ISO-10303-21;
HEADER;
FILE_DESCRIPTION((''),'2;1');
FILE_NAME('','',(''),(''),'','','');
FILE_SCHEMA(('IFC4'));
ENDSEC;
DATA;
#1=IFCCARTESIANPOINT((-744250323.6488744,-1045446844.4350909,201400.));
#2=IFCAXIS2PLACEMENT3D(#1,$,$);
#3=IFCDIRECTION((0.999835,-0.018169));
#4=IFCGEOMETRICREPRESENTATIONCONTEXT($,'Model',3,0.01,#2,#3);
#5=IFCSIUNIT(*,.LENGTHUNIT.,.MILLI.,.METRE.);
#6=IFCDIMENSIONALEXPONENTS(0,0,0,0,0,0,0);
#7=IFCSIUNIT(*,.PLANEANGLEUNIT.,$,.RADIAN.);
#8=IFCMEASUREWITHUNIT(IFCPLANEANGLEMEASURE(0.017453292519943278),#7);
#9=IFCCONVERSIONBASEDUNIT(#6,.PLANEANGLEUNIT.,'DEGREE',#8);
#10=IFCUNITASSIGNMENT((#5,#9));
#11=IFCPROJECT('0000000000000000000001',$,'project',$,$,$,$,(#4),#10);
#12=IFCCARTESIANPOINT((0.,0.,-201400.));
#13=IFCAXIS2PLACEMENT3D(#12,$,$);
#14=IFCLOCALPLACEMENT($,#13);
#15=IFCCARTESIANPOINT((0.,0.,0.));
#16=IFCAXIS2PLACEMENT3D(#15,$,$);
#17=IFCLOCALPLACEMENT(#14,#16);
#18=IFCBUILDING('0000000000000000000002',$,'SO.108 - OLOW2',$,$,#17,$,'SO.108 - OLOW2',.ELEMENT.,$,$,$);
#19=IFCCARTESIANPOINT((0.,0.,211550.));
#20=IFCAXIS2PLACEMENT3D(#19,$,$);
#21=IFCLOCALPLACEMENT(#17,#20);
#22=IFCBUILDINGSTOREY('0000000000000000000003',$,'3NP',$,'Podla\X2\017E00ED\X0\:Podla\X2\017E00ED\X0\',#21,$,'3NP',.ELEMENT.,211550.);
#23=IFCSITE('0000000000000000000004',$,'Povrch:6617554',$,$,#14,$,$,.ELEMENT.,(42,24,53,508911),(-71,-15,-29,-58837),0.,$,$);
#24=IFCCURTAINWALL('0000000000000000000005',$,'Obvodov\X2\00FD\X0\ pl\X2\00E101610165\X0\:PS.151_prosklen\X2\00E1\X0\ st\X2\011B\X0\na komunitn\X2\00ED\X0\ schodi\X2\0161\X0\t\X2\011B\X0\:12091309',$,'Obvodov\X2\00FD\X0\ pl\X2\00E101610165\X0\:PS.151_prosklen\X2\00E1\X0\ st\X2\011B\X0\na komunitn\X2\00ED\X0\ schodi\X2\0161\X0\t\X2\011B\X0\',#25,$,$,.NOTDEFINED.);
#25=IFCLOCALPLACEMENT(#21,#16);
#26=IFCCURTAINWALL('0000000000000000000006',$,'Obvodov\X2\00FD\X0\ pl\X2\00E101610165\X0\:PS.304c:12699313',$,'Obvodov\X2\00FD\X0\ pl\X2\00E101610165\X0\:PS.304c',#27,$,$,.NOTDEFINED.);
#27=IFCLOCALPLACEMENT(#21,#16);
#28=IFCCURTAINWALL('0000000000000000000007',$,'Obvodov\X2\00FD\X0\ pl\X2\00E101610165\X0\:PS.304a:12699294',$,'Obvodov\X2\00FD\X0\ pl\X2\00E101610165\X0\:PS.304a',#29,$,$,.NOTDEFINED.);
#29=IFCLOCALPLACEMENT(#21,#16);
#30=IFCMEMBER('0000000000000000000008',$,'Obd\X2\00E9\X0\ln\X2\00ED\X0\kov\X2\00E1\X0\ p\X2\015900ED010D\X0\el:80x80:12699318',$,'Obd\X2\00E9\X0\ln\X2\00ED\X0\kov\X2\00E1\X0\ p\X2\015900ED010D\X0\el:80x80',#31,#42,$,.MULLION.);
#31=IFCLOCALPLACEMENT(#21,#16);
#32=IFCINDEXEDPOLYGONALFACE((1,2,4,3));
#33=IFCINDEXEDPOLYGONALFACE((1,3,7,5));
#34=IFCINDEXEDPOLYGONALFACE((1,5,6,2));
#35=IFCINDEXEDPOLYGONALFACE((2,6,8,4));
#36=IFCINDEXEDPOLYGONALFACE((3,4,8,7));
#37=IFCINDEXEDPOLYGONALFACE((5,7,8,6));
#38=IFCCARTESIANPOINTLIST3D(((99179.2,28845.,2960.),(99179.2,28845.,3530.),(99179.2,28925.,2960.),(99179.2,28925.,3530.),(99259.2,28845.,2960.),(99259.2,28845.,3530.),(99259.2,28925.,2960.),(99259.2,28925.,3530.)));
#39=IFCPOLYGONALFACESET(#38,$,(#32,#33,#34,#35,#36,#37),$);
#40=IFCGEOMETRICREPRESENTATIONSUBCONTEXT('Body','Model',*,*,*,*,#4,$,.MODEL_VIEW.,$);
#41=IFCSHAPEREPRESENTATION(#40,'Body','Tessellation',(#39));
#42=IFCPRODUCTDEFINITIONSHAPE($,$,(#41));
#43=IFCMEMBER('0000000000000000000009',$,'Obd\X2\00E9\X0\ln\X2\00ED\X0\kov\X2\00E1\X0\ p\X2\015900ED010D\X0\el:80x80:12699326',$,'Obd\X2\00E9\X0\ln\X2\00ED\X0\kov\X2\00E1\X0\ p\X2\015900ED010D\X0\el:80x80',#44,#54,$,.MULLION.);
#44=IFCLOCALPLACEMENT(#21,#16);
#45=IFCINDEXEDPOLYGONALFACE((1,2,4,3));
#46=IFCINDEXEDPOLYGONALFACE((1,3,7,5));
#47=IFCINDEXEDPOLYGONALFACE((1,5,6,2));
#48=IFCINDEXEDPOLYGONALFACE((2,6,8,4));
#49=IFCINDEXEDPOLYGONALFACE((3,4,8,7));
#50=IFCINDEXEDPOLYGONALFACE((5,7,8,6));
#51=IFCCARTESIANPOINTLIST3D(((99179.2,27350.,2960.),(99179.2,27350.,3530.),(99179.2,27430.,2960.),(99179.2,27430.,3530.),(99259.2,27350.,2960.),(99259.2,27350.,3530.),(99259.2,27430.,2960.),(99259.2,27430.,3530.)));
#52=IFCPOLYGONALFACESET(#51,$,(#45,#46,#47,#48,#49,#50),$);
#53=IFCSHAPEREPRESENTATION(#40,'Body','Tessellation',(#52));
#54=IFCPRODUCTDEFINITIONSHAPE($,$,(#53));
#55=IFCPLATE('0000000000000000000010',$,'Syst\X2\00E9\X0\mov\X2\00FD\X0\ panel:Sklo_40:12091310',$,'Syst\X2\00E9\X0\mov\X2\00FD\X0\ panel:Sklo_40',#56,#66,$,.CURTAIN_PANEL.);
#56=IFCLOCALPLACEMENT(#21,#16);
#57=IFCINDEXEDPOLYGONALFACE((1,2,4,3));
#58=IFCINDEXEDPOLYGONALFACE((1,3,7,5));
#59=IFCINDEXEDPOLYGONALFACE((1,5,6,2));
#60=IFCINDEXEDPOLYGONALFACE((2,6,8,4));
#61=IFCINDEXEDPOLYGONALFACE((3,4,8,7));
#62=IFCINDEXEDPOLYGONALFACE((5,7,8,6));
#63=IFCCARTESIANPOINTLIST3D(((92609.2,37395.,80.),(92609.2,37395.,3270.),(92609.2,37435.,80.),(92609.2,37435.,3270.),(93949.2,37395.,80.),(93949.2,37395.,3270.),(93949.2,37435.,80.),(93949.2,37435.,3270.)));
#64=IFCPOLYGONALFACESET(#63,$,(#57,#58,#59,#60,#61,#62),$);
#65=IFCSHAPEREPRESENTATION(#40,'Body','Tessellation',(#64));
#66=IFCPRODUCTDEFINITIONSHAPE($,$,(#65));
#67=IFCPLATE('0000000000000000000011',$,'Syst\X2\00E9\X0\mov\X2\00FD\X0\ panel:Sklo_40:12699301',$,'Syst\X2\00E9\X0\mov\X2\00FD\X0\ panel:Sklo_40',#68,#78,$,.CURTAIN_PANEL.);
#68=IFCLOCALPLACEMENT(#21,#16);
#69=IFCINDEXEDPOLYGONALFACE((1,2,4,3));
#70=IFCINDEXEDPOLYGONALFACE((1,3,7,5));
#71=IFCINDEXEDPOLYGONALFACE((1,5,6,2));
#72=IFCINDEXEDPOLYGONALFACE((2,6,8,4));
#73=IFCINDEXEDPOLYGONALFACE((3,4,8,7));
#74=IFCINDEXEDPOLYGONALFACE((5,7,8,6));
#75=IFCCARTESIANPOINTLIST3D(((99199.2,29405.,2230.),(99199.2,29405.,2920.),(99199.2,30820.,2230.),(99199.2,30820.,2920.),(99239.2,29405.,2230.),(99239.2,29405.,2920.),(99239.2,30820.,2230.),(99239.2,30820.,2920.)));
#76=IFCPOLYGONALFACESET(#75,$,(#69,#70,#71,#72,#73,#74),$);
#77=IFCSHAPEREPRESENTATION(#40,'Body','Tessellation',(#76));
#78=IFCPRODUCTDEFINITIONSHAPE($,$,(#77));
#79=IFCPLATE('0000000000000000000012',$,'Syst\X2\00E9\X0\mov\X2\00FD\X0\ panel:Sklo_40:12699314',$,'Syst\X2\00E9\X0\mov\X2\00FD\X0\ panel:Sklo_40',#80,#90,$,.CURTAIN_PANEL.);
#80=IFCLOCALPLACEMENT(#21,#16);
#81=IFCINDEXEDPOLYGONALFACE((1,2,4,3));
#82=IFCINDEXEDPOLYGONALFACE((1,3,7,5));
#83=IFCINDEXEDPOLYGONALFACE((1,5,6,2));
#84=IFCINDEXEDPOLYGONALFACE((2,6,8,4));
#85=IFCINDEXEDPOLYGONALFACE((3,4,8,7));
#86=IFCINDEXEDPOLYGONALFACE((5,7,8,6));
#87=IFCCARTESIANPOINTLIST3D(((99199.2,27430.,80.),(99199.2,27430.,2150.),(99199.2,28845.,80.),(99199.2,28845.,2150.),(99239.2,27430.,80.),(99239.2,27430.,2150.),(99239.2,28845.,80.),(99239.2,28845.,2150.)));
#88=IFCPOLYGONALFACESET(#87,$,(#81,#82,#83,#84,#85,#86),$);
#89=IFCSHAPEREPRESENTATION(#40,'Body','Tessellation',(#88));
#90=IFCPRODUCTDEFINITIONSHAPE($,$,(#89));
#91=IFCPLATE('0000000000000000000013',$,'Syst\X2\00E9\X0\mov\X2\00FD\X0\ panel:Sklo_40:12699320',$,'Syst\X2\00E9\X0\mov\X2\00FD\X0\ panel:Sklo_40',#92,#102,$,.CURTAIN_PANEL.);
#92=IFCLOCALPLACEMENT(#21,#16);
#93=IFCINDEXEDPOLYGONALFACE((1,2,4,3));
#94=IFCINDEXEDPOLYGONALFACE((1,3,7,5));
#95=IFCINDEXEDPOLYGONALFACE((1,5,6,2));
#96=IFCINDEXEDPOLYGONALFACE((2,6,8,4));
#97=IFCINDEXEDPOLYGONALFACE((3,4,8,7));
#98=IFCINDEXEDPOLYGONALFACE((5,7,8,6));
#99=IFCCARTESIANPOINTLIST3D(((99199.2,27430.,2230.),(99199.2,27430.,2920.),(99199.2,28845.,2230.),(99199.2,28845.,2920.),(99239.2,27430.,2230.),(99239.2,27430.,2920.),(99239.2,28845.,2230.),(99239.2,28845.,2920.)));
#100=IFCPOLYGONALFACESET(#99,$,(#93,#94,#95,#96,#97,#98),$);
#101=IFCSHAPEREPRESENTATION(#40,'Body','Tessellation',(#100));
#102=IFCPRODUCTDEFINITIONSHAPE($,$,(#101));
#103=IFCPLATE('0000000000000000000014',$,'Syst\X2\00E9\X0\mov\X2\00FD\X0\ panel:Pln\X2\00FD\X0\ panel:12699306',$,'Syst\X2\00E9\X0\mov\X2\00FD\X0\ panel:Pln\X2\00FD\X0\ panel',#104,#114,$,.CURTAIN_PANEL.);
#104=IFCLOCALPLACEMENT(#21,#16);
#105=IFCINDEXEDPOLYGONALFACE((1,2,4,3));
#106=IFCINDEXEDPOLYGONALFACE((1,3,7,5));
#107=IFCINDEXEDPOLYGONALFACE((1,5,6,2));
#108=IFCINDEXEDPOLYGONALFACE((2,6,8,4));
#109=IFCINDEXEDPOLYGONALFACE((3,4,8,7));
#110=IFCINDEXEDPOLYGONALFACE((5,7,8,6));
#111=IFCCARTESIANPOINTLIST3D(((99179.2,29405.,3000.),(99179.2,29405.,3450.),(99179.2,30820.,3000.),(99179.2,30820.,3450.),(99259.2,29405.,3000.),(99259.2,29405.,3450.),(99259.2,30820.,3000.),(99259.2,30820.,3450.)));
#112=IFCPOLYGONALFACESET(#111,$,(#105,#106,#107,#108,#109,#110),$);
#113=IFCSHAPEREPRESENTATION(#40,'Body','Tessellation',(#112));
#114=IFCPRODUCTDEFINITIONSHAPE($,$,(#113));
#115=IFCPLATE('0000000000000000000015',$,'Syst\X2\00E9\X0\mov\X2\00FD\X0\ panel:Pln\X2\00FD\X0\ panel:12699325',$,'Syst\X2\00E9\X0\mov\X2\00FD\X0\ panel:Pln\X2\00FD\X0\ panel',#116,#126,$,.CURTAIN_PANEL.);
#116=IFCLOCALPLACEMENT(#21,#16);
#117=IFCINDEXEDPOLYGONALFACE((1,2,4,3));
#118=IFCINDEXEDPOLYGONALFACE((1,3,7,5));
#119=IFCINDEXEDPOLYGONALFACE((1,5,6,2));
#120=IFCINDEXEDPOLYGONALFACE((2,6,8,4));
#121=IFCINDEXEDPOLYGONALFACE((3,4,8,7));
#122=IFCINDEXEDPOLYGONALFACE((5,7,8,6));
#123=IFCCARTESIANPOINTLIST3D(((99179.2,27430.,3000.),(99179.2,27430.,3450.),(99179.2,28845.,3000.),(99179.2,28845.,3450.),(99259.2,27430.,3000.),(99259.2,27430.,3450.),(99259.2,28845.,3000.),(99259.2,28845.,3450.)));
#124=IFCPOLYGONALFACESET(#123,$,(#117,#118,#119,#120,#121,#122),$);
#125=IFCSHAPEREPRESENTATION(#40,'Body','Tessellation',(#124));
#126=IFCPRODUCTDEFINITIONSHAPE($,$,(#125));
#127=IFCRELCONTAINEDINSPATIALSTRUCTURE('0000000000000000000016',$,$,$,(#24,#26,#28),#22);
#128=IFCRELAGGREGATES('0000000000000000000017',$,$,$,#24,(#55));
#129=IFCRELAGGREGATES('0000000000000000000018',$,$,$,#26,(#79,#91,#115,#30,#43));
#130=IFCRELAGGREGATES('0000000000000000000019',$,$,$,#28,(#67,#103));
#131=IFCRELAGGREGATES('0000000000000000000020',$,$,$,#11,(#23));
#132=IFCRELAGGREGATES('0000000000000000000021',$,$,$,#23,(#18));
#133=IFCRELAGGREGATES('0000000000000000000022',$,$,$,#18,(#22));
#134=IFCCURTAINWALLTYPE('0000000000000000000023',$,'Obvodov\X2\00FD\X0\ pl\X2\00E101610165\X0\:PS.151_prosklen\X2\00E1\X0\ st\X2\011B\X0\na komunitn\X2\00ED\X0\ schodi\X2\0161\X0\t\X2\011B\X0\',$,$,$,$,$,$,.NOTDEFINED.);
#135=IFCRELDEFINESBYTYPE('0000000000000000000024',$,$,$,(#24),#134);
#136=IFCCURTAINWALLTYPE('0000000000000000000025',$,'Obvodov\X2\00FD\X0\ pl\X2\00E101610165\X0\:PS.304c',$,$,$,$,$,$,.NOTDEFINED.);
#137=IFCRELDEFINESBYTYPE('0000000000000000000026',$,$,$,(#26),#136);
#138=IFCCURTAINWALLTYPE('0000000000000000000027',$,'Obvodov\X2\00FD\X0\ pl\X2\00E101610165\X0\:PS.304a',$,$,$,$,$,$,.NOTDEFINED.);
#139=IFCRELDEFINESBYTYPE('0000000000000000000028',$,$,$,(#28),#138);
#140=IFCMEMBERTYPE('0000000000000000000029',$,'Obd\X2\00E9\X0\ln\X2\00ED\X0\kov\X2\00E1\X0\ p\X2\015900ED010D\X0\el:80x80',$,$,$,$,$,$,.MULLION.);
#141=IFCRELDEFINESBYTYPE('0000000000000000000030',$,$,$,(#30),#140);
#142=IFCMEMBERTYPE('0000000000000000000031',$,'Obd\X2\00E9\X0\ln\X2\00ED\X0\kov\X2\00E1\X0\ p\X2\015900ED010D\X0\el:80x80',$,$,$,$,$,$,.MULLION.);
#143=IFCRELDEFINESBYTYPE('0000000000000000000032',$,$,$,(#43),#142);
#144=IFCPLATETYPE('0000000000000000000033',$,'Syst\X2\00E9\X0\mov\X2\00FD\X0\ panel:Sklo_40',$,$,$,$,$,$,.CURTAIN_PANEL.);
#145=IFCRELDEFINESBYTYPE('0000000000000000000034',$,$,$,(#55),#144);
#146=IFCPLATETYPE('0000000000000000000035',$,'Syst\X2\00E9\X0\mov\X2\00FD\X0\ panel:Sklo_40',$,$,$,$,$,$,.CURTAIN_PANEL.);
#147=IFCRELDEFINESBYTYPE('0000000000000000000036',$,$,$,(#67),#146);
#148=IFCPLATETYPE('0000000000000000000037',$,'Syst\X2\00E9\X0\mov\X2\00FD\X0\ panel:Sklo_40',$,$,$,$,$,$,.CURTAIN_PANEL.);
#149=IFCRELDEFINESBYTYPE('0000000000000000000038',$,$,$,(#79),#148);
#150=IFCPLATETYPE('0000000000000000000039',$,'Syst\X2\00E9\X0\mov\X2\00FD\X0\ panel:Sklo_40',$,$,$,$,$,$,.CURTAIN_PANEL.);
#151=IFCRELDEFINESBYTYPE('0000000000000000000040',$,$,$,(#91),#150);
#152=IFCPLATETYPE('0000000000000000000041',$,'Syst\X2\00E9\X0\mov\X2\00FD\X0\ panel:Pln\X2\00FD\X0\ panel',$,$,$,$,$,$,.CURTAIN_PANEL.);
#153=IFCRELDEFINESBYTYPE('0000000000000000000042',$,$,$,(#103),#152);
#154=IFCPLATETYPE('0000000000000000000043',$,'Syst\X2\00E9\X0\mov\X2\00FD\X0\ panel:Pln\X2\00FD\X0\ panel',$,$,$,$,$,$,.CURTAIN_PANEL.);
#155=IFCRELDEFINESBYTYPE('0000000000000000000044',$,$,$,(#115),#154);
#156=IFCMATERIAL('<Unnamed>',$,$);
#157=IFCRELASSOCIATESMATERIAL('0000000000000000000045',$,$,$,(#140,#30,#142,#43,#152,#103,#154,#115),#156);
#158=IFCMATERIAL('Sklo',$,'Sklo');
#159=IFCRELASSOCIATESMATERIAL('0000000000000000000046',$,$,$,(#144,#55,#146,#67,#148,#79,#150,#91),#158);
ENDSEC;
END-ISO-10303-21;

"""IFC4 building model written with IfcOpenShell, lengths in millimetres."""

from ifc_helpers import new_model, entity, si_unit, converted_unit, direction, frame, origin, place, context, subcontext, project, spatial, indexed_curve, outline, extrude, source, transform, mapped, material, type_object, type_shapes, element, aggregate, save


model = new_model("IFC4")

# Units and contexts
model_context = context("Model", 3, precision=0.01, world=frame((-744250323.6488744, -1045446844.4350909, 201400.0)), true_north=direction((0.999835, -0.018169)))
body_context = subcontext(model_context, "Body", "Model", "MODEL_VIEW")
ifc_project = project(units=[si_unit("LENGTHUNIT", "METRE", prefix="MILLI"), converted_unit("PLANEANGLEUNIT", "DEGREE", entity("IfcPlaneAngleMeasure", 0.017453292519943278), si_unit("PLANEANGLEUNIT", "RADIAN"), dimensions=[0, 0, 0, 0, 0, 0, 0])], contexts=[model_context])

# Site, building, storey
site_placement = place(None, frame((0.0, 0.0, -201400.0)))
site = spatial("IfcSite", under=ifc_project, at=site_placement, Name="Povrch:6617554", CompositionType="ELEMENT", RefLatitude=(42, 24, 53, 508911), RefLongitude=(-71, -15, -29, -58837), RefElevation=0.0)
building_placement = place(site_placement, origin())
building = spatial("IfcBuilding", under=site, at=building_placement, Name="SO.108 - OLOW2", LongName="SO.108 - OLOW2", CompositionType="ELEMENT")
storey_placement = place(building_placement, frame((0.0, 0.0, 211550.0)))
storey = spatial("IfcBuildingStorey", under=building, at=storey_placement, Name="3NP", ObjectType="Podlaží:Podlaží", LongName="3NP", CompositionType="ELEMENT", Elevation=211550.0)

# Curtain walls
curtain_wall_type_1 = type_object("IfcCurtainWallType", Name="Obvodový plášť:PS.151_prosklená stěna komunitní schodiště", PredefinedType="NOTDEFINED")
curtain_wall_1_placement = place(storey_placement, frame((0.0, 0.0, -211550.0)))
curtain_wall_1 = element("IfcCurtainWall", 1, at=curtain_wall_1_placement, inside=storey, type_object=curtain_wall_type_1, Name="Obvodový plášť:PS.151_prosklená stěna komunitní schodiště:12091309", ObjectType="Obvodový plášť:PS.151_prosklená stěna komunitní schodiště", PredefinedType="NOTDEFINED")
ifc_material_1 = material(Name="<Unnamed>")
curtain_wall_type_2 = type_object("IfcCurtainWallType", Name="Obvodový plášť:PS.304c", PredefinedType="NOTDEFINED")
curtain_wall_2_placement = place(storey_placement, frame((0.0, 0.0, -211550.0)))
curtain_wall_2 = element("IfcCurtainWall", 2, at=curtain_wall_2_placement, inside=storey, type_object=curtain_wall_type_2, Name="Obvodový plášť:PS.304c:12699313", ObjectType="Obvodový plášť:PS.304c", PredefinedType="NOTDEFINED")
curtain_wall_type_3 = type_object("IfcCurtainWallType", Name="Obvodový plášť:PS.304a", PredefinedType="NOTDEFINED")
curtain_wall_3_placement = place(storey_placement, frame((0.0, 0.0, -211550.0)))
curtain_wall_3 = element("IfcCurtainWall", 3, at=curtain_wall_3_placement, inside=storey, type_object=curtain_wall_type_3, Name="Obvodový plášť:PS.304a:12699294", ObjectType="Obvodový plášť:PS.304a", PredefinedType="NOTDEFINED")

# Members
member_type_1 = type_object("IfcMemberType", Name="Obdélníková příčel:80x80", PredefinedType="MULLION", material=ifc_material_1)
shared_shape_1 = source(origin(), body_context, "Body", "SweptSolid", [
    extrude(outline(indexed_curve([(-40.0, -40.0), (40.0, -40.0), (40.0, 40.0), (-40.0, 40.0), (-40.0, -40.0)], self_intersect=False)), frame((-40.0, 0.0, -570.0), z_axis=(0.0, 0.0, 1.0), x_axis=(-1.0, 0.0, 0.0)), (0.0, 0.0, 1.0), 570.0),
])
type_shapes(member_type_1, [shared_shape_1])
member_1_placement = place(curtain_wall_2_placement, frame((99219.2, 28925.0, 215080.0), z_axis=(0.0, 0.0, 1.0), x_axis=(0.0, 1.0, 0.0)))
member_1 = element("IfcMember", 4, at=member_1_placement, type_object=member_type_1, material=ifc_material_1, Name="Obdélníková příčel:80x80:12699318", ObjectType="Obdélníková příčel:80x80", PredefinedType="MULLION", context=body_context, shape_type="MappedRepresentation", body=[
    mapped(shared_shape_1, transform((0.0, 0.0, 0.0), scale=1.0)),
])
member_type_2 = type_object("IfcMemberType", Name="Obdélníková příčel:80x80", PredefinedType="MULLION", material=ifc_material_1)
shared_shape_2 = source(origin(), body_context, "Body", "SweptSolid", [
    extrude(outline(indexed_curve([(-40.0, -40.0), (40.0, -40.0), (40.0, 40.0), (-40.0, 40.0), (-40.0, -40.0)], self_intersect=False)), frame((-40.0, 0.0, -570.0), z_axis=(0.0, 0.0, 1.0), x_axis=(-1.0, 0.0, 0.0)), (0.0, 0.0, 1.0), 570.0),
])
type_shapes(member_type_2, [shared_shape_2])
member_2_placement = place(curtain_wall_2_placement, frame((99219.2, 27350.0, 214510.0), z_axis=(0.0, 0.0, -1.0), x_axis=(0.0, -1.0, 0.0)))
member_2 = element("IfcMember", 5, at=member_2_placement, type_object=member_type_2, material=ifc_material_1, Name="Obdélníková příčel:80x80:12699326", ObjectType="Obdélníková příčel:80x80", PredefinedType="MULLION", context=body_context, shape_type="MappedRepresentation", body=[
    mapped(shared_shape_2, transform((0.0, 0.0, 0.0), scale=1.0)),
])

# Plates
ifc_material_2 = material(Name="Sklo", Category="Sklo")
plate_type_1 = type_object("IfcPlateType", Name="Systémový panel:Sklo_40", PredefinedType="CURTAIN_PANEL", material=ifc_material_2)
shared_shape_3 = source(origin(), body_context, "Body", "SweptSolid", [
    extrude(outline(indexed_curve([(-20.0, -670.0), (20.0, -670.0), (20.0, 670.0), (-20.0, 670.0), (-20.0, -670.0)], self_intersect=False)), frame((0.0, 0.0, 0.0), z_axis=(0.0, 0.0, 1.0), x_axis=(0.0, 1.0, 0.0)), (0.0, 0.0, 1.0), 3190.0),
])
type_shapes(plate_type_1, [shared_shape_3])
plate_1_placement = place(curtain_wall_1_placement, frame((93279.2, 37415.0, 211630.0)))
plate_1 = element("IfcPlate", 6, at=plate_1_placement, type_object=plate_type_1, material=ifc_material_2, Name="Systémový panel:Sklo_40:12091310", ObjectType="Systémový panel:Sklo_40", PredefinedType="CURTAIN_PANEL", context=body_context, shape_type="MappedRepresentation", body=[
    mapped(shared_shape_3, transform((0.0, 0.0, 0.0), scale=1.0)),
])
aggregate(curtain_wall_1, [plate_1])
plate_type_2 = type_object("IfcPlateType", Name="Systémový panel:Sklo_40", PredefinedType="CURTAIN_PANEL", material=ifc_material_2)
shared_shape_4 = source(origin(), body_context, "Body", "SweptSolid", [
    extrude(outline(indexed_curve([(-20.0, -707.5), (20.0, -707.5), (20.0, 707.5), (-20.0, 707.5), (-20.0, -707.5)], self_intersect=False)), frame((0.0, 0.0, 0.0), z_axis=(0.0, 0.0, 1.0), x_axis=(0.0, 1.0, 0.0)), (0.0, 0.0, 1.0), 690.0),
])
type_shapes(plate_type_2, [shared_shape_4])
plate_2_placement = place(curtain_wall_3_placement, frame((99219.2, 30112.5, 213780.0), z_axis=(0.0, 0.0, 1.0), x_axis=(0.0, -1.0, 0.0)))
plate_2 = element("IfcPlate", 7, at=plate_2_placement, type_object=plate_type_2, material=ifc_material_2, Name="Systémový panel:Sklo_40:12699301", ObjectType="Systémový panel:Sklo_40", PredefinedType="CURTAIN_PANEL", context=body_context, shape_type="MappedRepresentation", body=[
    mapped(shared_shape_4, transform((0.0, 0.0, 0.0), scale=1.0)),
])
plate_type_3 = type_object("IfcPlateType", Name="Systémový panel:Sklo_40", PredefinedType="CURTAIN_PANEL", material=ifc_material_2)
shared_shape_5 = source(origin(), body_context, "Body", "SweptSolid", [
    extrude(outline(indexed_curve([(-20.0, -707.5), (20.0, -707.5), (20.0, 707.5), (-20.0, 707.5), (-20.0, -707.5)], self_intersect=False)), frame((0.0, 0.0, 0.0), z_axis=(0.0, 0.0, 1.0), x_axis=(0.0, 1.0, 0.0)), (0.0, 0.0, 1.0), 2070.0),
])
type_shapes(plate_type_3, [shared_shape_5])
plate_3_placement = place(curtain_wall_2_placement, frame((99219.2, 28137.5, 211630.0), z_axis=(0.0, 0.0, 1.0), x_axis=(0.0, -1.0, 0.0)))
plate_3 = element("IfcPlate", 8, at=plate_3_placement, type_object=plate_type_3, material=ifc_material_2, Name="Systémový panel:Sklo_40:12699314", ObjectType="Systémový panel:Sklo_40", PredefinedType="CURTAIN_PANEL", context=body_context, shape_type="MappedRepresentation", body=[
    mapped(shared_shape_5, transform((0.0, 0.0, 0.0), scale=1.0)),
])
plate_type_4 = type_object("IfcPlateType", Name="Systémový panel:Sklo_40", PredefinedType="CURTAIN_PANEL", material=ifc_material_2)
shared_shape_6 = source(origin(), body_context, "Body", "SweptSolid", [
    extrude(outline(indexed_curve([(-20.0, -707.5), (20.0, -707.5), (20.0, 707.5), (-20.0, 707.5), (-20.0, -707.5)], self_intersect=False)), frame((0.0, 0.0, 0.0), z_axis=(0.0, 0.0, 1.0), x_axis=(0.0, 1.0, 0.0)), (0.0, 0.0, 1.0), 690.0),
])
type_shapes(plate_type_4, [shared_shape_6])
plate_4_placement = place(curtain_wall_2_placement, frame((99219.2, 28137.5, 213780.0), z_axis=(0.0, 0.0, 1.0), x_axis=(0.0, -1.0, 0.0)))
plate_4 = element("IfcPlate", 9, at=plate_4_placement, type_object=plate_type_4, material=ifc_material_2, Name="Systémový panel:Sklo_40:12699320", ObjectType="Systémový panel:Sklo_40", PredefinedType="CURTAIN_PANEL", context=body_context, shape_type="MappedRepresentation", body=[
    mapped(shared_shape_6, transform((0.0, 0.0, 0.0), scale=1.0)),
])
plate_type_5 = type_object("IfcPlateType", Name="Systémový panel:Plný panel", PredefinedType="CURTAIN_PANEL", material=ifc_material_1)
shared_shape_7 = source(origin(), body_context, "Body", "SweptSolid", [
    extrude(outline(indexed_curve([(-40.0, -707.5), (40.0, -707.5), (40.0, 707.5), (-40.0, 707.5), (-40.0, -707.5)], self_intersect=False)), frame((0.0, 0.0, 0.0), z_axis=(0.0, 0.0, 1.0), x_axis=(0.0, 1.0, 0.0)), (0.0, 0.0, 1.0), 450.0),
])
type_shapes(plate_type_5, [shared_shape_7])
plate_5_placement = place(curtain_wall_3_placement, frame((99219.2, 30112.5, 214550.0), z_axis=(0.0, 0.0, 1.0), x_axis=(0.0, -1.0, 0.0)))
plate_5 = element("IfcPlate", 10, at=plate_5_placement, type_object=plate_type_5, material=ifc_material_1, Name="Systémový panel:Plný panel:12699306", ObjectType="Systémový panel:Plný panel", PredefinedType="CURTAIN_PANEL", context=body_context, shape_type="MappedRepresentation", body=[
    mapped(shared_shape_7, transform((0.0, 0.0, 0.0), scale=1.0)),
])
plate_type_6 = type_object("IfcPlateType", Name="Systémový panel:Plný panel", PredefinedType="CURTAIN_PANEL", material=ifc_material_1)
shared_shape_8 = source(origin(), body_context, "Body", "SweptSolid", [
    extrude(outline(indexed_curve([(-40.0, -707.5), (40.0, -707.5), (40.0, 707.5), (-40.0, 707.5), (-40.0, -707.5)], self_intersect=False)), frame((0.0, 0.0, 0.0), z_axis=(0.0, 0.0, 1.0), x_axis=(0.0, 1.0, 0.0)), (0.0, 0.0, 1.0), 450.0),
])
type_shapes(plate_type_6, [shared_shape_8])
plate_6_placement = place(curtain_wall_2_placement, frame((99219.2, 28137.5, 214550.0), z_axis=(0.0, 0.0, 1.0), x_axis=(0.0, -1.0, 0.0)))
plate_6 = element("IfcPlate", 11, at=plate_6_placement, type_object=plate_type_6, material=ifc_material_1, Name="Systémový panel:Plný panel:12699325", ObjectType="Systémový panel:Plný panel", PredefinedType="CURTAIN_PANEL", context=body_context, shape_type="MappedRepresentation", body=[
    mapped(shared_shape_8, transform((0.0, 0.0, 0.0), scale=1.0)),
])
aggregate(curtain_wall_2, [plate_3, plate_4, plate_6, member_1, member_2])

aggregate(curtain_wall_3, [plate_2, plate_5])

save(model, "model.ifc")
